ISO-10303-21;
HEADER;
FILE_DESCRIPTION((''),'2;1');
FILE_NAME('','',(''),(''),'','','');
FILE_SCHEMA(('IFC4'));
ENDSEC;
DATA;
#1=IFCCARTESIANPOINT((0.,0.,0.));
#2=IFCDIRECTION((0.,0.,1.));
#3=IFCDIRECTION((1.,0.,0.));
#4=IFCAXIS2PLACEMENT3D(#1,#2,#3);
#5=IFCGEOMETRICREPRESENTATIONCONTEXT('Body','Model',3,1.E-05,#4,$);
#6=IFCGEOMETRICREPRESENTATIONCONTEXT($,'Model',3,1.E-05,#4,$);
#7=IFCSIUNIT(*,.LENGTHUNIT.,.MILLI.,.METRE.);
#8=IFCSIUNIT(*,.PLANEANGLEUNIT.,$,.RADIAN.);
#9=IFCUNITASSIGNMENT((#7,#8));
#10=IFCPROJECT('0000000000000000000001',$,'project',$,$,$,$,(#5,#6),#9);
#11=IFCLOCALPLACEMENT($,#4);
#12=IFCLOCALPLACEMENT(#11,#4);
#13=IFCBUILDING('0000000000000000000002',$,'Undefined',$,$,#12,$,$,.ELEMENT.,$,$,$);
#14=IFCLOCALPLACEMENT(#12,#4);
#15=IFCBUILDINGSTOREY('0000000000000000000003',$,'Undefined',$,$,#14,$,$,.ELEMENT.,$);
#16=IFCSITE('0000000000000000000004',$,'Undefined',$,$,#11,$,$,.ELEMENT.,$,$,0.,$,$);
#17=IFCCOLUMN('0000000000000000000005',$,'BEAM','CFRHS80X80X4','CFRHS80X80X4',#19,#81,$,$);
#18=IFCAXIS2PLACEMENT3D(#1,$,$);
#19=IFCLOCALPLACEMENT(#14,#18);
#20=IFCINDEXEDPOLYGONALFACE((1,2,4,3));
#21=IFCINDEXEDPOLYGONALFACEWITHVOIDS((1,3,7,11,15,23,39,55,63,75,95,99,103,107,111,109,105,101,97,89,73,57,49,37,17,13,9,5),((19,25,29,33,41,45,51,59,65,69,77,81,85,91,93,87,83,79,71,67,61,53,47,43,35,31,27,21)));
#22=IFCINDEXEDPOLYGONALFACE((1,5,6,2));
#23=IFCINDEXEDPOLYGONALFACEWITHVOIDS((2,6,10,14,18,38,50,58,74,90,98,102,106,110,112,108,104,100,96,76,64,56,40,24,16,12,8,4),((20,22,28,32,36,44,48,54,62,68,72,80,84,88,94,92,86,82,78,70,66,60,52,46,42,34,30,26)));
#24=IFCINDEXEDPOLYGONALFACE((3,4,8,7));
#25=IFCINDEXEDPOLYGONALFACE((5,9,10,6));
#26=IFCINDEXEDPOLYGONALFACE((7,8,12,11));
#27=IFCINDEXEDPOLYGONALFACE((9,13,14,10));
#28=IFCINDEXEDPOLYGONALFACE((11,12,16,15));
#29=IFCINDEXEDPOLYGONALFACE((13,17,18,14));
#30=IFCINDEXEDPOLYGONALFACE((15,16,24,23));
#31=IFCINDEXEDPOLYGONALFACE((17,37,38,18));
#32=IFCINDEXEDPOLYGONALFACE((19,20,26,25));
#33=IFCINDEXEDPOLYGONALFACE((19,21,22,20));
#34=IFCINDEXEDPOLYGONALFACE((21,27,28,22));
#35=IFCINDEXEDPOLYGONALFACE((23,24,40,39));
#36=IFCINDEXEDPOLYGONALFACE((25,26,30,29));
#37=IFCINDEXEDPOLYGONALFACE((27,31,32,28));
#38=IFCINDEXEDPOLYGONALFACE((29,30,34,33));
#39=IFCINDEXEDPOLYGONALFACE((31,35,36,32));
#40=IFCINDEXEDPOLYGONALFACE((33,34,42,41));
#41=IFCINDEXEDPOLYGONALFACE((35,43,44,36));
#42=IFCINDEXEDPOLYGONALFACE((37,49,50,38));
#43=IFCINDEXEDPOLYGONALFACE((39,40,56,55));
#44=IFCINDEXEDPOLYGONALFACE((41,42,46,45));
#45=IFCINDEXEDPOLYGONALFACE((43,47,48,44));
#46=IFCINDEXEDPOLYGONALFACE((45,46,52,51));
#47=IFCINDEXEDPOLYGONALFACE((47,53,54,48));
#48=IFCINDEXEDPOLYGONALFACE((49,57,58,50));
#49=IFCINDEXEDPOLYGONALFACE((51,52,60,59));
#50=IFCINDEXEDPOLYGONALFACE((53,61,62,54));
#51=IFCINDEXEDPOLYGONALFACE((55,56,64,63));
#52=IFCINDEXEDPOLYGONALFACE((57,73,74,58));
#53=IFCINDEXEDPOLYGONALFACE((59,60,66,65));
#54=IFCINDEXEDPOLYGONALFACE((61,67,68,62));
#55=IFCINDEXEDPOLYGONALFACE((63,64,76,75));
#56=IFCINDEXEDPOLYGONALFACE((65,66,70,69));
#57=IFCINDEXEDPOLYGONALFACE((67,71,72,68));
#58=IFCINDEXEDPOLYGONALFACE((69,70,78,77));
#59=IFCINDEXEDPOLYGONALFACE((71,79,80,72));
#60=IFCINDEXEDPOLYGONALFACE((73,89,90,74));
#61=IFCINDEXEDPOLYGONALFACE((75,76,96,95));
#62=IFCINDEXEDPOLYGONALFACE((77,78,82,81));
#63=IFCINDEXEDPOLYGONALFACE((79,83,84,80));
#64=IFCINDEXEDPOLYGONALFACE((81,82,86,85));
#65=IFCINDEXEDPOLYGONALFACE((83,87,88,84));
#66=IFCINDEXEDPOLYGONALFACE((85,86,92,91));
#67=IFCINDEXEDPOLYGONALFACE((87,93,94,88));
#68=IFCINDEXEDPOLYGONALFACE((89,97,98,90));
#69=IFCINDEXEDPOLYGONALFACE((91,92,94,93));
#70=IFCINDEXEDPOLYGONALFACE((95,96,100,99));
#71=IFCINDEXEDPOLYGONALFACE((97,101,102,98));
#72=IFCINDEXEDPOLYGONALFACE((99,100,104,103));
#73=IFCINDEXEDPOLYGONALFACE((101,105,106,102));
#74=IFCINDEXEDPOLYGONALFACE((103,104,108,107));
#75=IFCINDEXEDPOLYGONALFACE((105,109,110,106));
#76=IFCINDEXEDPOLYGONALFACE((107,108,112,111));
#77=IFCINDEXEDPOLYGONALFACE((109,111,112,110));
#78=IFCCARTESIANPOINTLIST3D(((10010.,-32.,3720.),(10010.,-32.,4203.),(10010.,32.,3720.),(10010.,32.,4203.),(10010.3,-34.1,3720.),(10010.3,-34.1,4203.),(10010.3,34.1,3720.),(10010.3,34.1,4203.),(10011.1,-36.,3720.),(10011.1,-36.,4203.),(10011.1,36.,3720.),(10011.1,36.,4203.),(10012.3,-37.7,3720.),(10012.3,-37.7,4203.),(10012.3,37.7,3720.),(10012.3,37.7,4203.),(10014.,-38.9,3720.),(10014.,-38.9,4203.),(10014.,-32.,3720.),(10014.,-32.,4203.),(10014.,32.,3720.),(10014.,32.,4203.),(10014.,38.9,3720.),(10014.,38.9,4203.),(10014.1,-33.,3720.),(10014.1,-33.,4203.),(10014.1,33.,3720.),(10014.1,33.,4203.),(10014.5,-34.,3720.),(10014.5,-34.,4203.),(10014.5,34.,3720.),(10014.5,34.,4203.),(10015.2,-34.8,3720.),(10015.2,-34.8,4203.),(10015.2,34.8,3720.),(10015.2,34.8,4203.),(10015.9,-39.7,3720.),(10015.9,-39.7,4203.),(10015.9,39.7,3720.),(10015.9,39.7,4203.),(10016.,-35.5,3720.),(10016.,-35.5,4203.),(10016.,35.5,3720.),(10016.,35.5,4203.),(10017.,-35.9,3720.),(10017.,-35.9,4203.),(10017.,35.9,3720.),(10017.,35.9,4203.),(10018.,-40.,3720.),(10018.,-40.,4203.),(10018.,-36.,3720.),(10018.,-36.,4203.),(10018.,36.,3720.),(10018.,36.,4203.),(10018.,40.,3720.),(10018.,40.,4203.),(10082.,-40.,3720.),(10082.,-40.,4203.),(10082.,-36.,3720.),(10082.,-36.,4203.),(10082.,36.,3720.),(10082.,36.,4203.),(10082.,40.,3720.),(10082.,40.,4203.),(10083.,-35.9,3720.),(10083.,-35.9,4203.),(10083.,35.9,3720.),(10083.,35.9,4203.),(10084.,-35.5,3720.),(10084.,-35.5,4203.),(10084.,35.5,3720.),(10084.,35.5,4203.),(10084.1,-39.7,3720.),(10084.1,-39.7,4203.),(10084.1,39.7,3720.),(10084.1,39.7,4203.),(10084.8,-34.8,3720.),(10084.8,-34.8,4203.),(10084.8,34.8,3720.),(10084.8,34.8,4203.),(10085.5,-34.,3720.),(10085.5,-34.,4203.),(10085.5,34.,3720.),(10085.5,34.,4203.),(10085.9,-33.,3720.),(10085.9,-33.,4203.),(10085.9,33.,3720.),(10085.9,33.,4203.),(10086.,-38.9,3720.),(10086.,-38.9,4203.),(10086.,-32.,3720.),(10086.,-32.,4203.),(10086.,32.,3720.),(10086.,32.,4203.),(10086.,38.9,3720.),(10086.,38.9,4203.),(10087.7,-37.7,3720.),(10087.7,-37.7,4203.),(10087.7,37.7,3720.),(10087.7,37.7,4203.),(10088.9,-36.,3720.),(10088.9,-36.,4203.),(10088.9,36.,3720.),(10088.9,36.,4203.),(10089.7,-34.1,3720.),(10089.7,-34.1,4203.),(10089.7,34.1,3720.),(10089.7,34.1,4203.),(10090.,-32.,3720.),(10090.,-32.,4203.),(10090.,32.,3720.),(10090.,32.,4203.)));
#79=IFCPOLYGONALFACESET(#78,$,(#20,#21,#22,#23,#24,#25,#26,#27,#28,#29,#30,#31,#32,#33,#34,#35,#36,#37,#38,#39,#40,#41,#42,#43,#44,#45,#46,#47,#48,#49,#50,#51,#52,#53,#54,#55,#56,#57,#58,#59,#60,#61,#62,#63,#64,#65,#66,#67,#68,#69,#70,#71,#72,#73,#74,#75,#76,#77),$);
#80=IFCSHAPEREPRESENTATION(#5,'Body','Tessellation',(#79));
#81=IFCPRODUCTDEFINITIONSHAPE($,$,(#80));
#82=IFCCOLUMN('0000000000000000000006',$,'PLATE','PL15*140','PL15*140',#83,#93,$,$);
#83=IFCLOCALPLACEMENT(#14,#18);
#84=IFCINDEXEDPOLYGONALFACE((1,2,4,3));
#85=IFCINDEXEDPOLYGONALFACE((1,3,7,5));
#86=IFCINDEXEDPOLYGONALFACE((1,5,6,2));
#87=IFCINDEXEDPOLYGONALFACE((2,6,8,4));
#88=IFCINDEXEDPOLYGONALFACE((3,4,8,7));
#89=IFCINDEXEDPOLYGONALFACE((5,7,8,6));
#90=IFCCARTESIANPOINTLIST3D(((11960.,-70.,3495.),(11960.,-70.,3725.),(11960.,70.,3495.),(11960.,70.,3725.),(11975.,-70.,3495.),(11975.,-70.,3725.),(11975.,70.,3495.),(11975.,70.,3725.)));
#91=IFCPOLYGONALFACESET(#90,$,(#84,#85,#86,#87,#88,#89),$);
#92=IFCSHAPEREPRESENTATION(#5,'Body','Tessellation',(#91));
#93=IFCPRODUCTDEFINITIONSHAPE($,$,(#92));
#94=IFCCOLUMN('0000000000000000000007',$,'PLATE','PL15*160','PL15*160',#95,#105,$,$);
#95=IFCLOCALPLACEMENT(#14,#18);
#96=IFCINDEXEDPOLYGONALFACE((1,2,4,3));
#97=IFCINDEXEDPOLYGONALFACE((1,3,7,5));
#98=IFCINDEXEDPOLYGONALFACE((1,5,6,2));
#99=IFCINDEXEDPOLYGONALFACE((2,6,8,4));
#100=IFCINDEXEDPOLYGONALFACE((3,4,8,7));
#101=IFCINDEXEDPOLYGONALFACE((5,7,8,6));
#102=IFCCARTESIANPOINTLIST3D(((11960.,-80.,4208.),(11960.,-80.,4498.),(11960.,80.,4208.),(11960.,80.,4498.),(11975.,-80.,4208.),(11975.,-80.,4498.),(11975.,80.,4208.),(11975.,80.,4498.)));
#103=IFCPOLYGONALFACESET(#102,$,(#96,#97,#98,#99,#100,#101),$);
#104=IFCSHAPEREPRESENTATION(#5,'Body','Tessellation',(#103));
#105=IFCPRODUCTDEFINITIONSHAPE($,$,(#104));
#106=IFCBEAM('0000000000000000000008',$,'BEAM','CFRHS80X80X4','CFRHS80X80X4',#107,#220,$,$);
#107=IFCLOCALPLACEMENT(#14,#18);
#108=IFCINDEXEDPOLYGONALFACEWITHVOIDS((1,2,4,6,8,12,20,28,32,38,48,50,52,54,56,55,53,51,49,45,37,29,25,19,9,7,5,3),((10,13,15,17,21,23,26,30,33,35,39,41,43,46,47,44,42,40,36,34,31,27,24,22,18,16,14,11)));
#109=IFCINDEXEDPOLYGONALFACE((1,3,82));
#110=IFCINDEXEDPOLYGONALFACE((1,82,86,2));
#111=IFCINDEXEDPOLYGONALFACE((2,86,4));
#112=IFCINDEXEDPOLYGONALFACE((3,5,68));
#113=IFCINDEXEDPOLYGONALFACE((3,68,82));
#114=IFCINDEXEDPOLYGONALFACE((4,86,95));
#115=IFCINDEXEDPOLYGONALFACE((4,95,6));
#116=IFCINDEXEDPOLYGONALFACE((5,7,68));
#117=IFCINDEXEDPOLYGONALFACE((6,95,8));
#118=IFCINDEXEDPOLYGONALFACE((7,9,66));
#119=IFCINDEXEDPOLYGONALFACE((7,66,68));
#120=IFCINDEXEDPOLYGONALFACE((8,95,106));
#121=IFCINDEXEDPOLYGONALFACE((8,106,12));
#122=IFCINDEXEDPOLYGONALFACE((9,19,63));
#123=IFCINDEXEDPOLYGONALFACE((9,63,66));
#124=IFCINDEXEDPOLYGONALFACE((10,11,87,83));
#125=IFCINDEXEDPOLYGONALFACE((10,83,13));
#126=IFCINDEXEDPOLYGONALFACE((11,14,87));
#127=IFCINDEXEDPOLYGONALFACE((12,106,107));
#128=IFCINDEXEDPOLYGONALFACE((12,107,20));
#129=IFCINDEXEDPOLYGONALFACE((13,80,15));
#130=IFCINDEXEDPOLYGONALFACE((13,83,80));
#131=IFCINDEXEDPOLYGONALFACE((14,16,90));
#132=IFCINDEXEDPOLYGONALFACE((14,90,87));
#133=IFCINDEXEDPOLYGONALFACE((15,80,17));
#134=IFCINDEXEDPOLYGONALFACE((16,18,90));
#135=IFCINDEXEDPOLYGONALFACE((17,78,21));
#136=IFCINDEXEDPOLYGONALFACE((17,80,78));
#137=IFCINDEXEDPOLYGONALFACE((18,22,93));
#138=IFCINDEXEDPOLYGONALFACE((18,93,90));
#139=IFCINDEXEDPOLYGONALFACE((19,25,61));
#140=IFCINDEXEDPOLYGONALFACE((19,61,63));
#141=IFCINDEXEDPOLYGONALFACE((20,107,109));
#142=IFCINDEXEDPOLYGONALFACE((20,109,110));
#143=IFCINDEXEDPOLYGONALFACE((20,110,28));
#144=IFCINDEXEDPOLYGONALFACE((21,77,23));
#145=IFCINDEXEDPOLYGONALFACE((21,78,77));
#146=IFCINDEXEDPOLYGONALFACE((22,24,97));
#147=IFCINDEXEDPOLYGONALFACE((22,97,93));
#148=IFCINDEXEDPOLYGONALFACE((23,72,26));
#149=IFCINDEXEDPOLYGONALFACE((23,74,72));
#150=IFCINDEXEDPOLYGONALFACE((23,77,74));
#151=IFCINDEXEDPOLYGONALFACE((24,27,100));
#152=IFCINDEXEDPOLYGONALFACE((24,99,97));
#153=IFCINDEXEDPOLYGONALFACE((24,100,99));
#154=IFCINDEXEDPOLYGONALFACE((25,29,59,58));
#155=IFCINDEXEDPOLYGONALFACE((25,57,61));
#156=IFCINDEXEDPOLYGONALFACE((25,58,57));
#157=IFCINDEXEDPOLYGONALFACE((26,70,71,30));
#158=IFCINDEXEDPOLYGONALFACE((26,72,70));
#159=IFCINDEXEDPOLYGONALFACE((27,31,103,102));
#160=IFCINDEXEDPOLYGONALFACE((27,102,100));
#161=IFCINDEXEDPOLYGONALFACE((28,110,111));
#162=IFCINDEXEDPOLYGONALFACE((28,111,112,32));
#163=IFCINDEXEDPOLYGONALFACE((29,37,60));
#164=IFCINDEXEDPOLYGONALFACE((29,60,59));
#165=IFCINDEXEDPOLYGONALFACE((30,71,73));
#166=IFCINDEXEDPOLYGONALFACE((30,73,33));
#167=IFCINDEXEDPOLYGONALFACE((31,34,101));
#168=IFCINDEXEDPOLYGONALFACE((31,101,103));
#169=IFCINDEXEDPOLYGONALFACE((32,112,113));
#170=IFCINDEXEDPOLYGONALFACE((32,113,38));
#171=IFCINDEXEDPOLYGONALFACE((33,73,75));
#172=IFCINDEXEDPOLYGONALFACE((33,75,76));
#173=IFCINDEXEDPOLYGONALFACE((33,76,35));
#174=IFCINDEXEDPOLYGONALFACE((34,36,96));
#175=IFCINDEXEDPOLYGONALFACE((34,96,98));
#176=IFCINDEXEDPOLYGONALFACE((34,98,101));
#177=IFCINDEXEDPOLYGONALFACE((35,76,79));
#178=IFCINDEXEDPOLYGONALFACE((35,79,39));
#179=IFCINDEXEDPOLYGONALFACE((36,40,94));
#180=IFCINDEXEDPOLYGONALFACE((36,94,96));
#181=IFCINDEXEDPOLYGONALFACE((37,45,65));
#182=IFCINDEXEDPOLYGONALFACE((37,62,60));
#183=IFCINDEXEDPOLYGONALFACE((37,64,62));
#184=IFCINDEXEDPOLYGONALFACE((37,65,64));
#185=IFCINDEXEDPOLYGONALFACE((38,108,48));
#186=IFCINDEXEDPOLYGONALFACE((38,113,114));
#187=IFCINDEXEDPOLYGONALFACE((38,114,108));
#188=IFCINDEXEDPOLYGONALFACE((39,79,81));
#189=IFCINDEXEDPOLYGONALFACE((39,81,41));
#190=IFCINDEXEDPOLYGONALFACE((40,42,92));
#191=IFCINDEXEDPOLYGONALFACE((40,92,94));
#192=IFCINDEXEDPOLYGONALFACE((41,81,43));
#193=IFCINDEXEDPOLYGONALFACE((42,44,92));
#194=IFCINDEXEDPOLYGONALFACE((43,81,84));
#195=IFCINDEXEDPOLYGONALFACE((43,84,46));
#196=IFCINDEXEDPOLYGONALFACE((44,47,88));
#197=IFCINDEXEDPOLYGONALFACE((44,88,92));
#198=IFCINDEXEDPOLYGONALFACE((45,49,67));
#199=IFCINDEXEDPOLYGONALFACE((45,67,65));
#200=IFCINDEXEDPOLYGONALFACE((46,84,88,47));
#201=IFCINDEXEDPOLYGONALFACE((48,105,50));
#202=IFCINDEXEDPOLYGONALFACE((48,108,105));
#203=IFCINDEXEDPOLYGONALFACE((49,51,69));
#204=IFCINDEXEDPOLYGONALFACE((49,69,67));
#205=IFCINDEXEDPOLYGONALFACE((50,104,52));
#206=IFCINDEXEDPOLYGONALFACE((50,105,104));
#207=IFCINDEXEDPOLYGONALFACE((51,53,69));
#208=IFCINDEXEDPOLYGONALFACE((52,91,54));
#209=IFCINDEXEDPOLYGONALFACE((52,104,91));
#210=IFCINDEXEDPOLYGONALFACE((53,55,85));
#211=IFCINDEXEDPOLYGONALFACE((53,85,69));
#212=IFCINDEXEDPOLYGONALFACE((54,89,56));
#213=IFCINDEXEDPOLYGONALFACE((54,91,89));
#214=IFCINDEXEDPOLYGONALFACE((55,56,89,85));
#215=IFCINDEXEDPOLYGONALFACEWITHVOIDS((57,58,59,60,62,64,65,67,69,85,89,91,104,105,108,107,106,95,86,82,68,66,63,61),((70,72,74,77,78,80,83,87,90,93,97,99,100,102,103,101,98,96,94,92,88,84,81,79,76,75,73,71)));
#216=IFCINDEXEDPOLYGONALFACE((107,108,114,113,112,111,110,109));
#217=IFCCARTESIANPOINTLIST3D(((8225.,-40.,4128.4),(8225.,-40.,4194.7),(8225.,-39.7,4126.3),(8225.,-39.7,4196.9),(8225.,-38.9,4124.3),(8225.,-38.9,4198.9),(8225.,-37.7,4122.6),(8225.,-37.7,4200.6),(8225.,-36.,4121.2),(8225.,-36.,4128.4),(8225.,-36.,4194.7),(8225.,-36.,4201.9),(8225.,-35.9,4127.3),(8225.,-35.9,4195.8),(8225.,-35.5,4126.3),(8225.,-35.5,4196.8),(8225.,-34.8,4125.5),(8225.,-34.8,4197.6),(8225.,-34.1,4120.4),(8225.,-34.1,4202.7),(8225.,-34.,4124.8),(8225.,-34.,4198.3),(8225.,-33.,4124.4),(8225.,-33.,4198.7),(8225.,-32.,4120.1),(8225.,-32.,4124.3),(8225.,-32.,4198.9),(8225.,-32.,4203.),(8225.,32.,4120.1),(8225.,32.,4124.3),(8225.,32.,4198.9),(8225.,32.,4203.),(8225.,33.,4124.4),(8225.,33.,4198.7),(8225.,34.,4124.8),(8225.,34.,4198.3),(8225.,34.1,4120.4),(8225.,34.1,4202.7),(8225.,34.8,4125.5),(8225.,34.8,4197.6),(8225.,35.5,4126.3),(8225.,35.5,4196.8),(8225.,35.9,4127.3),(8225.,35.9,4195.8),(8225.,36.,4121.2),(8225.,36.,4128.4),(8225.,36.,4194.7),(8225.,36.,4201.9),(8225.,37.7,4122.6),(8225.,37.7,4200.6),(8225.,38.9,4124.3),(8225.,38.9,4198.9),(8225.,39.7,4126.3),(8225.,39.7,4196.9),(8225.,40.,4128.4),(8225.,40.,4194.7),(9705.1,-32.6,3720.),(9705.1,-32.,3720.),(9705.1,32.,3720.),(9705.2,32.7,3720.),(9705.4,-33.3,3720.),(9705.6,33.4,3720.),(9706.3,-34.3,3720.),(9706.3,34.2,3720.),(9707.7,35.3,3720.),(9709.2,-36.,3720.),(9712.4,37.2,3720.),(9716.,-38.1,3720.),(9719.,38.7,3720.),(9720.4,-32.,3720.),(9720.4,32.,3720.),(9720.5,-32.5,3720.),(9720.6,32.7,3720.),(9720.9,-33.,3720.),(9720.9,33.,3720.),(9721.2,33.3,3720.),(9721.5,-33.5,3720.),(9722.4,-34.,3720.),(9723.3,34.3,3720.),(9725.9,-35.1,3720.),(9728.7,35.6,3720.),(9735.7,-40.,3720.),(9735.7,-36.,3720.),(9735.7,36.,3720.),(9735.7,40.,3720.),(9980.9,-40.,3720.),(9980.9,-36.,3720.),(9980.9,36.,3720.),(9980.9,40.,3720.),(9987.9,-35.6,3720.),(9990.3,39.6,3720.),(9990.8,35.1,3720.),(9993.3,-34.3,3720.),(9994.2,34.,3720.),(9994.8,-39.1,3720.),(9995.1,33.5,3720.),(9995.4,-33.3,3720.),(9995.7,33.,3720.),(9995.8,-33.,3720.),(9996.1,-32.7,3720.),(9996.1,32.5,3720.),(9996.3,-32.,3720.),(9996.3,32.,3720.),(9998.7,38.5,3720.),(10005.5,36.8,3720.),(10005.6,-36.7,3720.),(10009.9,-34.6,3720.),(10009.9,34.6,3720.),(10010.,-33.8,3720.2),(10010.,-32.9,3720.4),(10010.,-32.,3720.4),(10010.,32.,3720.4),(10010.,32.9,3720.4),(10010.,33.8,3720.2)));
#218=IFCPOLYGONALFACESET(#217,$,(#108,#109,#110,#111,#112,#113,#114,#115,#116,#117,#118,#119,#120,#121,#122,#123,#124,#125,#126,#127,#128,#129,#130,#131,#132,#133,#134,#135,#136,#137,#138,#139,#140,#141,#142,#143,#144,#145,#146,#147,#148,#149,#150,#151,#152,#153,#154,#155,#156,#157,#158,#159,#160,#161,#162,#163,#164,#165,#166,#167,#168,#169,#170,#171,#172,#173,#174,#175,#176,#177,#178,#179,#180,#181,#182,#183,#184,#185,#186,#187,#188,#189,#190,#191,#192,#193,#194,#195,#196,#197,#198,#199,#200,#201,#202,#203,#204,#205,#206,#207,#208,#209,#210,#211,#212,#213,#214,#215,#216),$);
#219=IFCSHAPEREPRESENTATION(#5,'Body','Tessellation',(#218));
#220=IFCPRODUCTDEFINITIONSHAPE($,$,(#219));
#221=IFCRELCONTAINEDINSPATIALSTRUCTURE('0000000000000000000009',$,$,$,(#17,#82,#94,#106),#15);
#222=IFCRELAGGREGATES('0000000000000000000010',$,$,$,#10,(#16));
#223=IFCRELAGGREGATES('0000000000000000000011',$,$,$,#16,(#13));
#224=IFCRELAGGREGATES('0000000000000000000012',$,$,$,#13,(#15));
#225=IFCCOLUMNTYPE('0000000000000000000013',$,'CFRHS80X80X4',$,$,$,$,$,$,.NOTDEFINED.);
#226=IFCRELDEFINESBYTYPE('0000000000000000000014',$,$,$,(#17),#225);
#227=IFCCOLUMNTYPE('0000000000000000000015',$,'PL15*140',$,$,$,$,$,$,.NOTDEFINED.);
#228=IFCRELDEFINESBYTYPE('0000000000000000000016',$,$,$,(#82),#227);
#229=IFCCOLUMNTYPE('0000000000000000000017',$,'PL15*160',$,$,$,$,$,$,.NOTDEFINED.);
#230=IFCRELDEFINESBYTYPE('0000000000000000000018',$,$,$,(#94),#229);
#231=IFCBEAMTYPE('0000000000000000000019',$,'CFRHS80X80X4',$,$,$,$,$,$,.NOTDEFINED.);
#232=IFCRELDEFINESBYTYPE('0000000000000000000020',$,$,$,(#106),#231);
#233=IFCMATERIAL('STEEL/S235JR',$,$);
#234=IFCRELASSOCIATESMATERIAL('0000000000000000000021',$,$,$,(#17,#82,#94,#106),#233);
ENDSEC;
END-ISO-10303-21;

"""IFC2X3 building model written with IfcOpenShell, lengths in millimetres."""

from ifc_helpers import new_model, si_unit, frame, origin_with_axes, origin_2d_with_axis, place, context, project, spatial, rectangle, hollow_rectangle, extrude, clip, halfspace, material, type_object, element, save


model = new_model("IFC2X3")

# Units and contexts
model_context_1 = context("Model", 3, precision=1e-05, world=origin_with_axes(), identifier="Body")
model_context_2 = context("Model", 3, precision=1e-05, world=origin_with_axes())
ifc_project = project(units=[si_unit("LENGTHUNIT", "METRE", prefix="MILLI"), si_unit("PLANEANGLEUNIT", "RADIAN")], contexts=[model_context_1, model_context_2])

# Site, building, storey
site_placement = place(None, origin_with_axes())
site = spatial("IfcSite", under=ifc_project, at=site_placement, Name="Undefined", CompositionType="ELEMENT", RefElevation=0.0)
building_placement = place(site_placement, origin_with_axes())
building = spatial("IfcBuilding", under=site, at=building_placement, Name="Undefined", CompositionType="ELEMENT")
storey_placement = place(building_placement, origin_with_axes())
storey = spatial("IfcBuildingStorey", under=building, at=storey_placement, Name="Undefined", CompositionType="ELEMENT")

# Columns
ifc_material = material(Name="STEEL/S235JR")
column_type_1 = type_object("IfcColumnType", Name="CFRHS80X80X4", PredefinedType="NOTDEFINED")
column_1_placement = place(storey_placement, frame((10050.0, 0.0, 3720.0), z_axis=(0.0, 0.0, 1.0), x_axis=(1.0, 0.0, 0.0)))
element("IfcColumn", 1, at=column_1_placement, inside=storey, type_object=column_type_1, material=ifc_material, Name="BEAM", Description="CFRHS80X80X4", ObjectType="CFRHS80X80X4", context=model_context_1, shape_type="SweptSolid", body=[
    extrude(hollow_rectangle(XDim=80.0, YDim=80.0, WallThickness=4.0, InnerFilletRadius=4.0, OuterFilletRadius=8.0, at=origin_2d_with_axis()), frame((0.0, 0.0, 483.0), z_axis=(0.0, 0.0, -1.0), x_axis=(0.0, 1.0, 0.0)), (0.0, 0.0, 1.0), 483.0),
])
column_type_2 = type_object("IfcColumnType", Name="PL15*140", PredefinedType="NOTDEFINED")
column_2_placement = place(storey_placement, frame((11967.5, 0.0, 3495.0), z_axis=(0.0, 0.0, 1.0), x_axis=(1.0, 0.0, 0.0)))
element("IfcColumn", 2, at=column_2_placement, inside=storey, type_object=column_type_2, material=ifc_material, Name="PLATE", Description="PL15*140", ObjectType="PL15*140", context=model_context_1, shape_type="SweptSolid", body=[
    extrude(rectangle(XDim=15.0, YDim=140.0, at=origin_2d_with_axis()), frame((0.0, 0.0, 230.0), z_axis=(0.0, 0.0, -1.0), x_axis=(1.0, 0.0, 0.0)), (0.0, 0.0, 1.0), 230.0),
])
column_type_3 = type_object("IfcColumnType", Name="PL15*160", PredefinedType="NOTDEFINED")
column_3_placement = place(storey_placement, frame((11967.5, 0.0, 4208.0), z_axis=(0.0, 0.0, 1.0), x_axis=(1.0, 0.0, 0.0)))
element("IfcColumn", 3, at=column_3_placement, inside=storey, type_object=column_type_3, material=ifc_material, Name="PLATE", Description="PL15*160", ObjectType="PL15*160", context=model_context_1, shape_type="SweptSolid", body=[
    extrude(rectangle(XDim=15.0, YDim=160.0, at=origin_2d_with_axis()), frame((0.0, 0.0, 290.0), z_axis=(0.0, 0.0, -1.0), x_axis=(1.0, 0.0, 0.0)), (0.0, 0.0, 1.0), 290.0),
])

# Beam
beam_type_1 = type_object("IfcBeamType", Name="CFRHS80X80X4", PredefinedType="NOTDEFINED")
beam_1_placement = place(storey_placement, frame((8215.3, 0.0, 4164.2), z_axis=(0.0, -1.0, 0.0), x_axis=(0.965344, 0.0, -0.260979)))
element("IfcBeam", 4, at=beam_1_placement, inside=storey, type_object=beam_type_1, material=ifc_material, Name="BEAM", Description="CFRHS80X80X4", ObjectType="CFRHS80X80X4", context=model_context_1, shape_type="Clipping", body=[
    clip(clip(extrude(hollow_rectangle(XDim=80.0, YDim=80.0, WallThickness=4.0, InnerFilletRadius=4.0, OuterFilletRadius=8.0, at=origin_2d_with_axis()), frame((1848.3, 0.0, 0.0), z_axis=(-1.0, 0.0, 0.0), x_axis=(0.0, -1.0, 0.0)), (0.0, 0.0, 1.0), 1997.1), halfspace(frame((1916.0, 57.8, -40.0), z_axis=(0.260979, -0.965344, 0.0), x_axis=(-0.965344, -0.260979, 0.0)), False)), halfspace(frame((24.8, -54.3, 0.0), z_axis=(0.965344, 0.260979, 0.0), x_axis=(0.0, 0.0, 1.0)), True)),
])

save(model, "model.ifc")
